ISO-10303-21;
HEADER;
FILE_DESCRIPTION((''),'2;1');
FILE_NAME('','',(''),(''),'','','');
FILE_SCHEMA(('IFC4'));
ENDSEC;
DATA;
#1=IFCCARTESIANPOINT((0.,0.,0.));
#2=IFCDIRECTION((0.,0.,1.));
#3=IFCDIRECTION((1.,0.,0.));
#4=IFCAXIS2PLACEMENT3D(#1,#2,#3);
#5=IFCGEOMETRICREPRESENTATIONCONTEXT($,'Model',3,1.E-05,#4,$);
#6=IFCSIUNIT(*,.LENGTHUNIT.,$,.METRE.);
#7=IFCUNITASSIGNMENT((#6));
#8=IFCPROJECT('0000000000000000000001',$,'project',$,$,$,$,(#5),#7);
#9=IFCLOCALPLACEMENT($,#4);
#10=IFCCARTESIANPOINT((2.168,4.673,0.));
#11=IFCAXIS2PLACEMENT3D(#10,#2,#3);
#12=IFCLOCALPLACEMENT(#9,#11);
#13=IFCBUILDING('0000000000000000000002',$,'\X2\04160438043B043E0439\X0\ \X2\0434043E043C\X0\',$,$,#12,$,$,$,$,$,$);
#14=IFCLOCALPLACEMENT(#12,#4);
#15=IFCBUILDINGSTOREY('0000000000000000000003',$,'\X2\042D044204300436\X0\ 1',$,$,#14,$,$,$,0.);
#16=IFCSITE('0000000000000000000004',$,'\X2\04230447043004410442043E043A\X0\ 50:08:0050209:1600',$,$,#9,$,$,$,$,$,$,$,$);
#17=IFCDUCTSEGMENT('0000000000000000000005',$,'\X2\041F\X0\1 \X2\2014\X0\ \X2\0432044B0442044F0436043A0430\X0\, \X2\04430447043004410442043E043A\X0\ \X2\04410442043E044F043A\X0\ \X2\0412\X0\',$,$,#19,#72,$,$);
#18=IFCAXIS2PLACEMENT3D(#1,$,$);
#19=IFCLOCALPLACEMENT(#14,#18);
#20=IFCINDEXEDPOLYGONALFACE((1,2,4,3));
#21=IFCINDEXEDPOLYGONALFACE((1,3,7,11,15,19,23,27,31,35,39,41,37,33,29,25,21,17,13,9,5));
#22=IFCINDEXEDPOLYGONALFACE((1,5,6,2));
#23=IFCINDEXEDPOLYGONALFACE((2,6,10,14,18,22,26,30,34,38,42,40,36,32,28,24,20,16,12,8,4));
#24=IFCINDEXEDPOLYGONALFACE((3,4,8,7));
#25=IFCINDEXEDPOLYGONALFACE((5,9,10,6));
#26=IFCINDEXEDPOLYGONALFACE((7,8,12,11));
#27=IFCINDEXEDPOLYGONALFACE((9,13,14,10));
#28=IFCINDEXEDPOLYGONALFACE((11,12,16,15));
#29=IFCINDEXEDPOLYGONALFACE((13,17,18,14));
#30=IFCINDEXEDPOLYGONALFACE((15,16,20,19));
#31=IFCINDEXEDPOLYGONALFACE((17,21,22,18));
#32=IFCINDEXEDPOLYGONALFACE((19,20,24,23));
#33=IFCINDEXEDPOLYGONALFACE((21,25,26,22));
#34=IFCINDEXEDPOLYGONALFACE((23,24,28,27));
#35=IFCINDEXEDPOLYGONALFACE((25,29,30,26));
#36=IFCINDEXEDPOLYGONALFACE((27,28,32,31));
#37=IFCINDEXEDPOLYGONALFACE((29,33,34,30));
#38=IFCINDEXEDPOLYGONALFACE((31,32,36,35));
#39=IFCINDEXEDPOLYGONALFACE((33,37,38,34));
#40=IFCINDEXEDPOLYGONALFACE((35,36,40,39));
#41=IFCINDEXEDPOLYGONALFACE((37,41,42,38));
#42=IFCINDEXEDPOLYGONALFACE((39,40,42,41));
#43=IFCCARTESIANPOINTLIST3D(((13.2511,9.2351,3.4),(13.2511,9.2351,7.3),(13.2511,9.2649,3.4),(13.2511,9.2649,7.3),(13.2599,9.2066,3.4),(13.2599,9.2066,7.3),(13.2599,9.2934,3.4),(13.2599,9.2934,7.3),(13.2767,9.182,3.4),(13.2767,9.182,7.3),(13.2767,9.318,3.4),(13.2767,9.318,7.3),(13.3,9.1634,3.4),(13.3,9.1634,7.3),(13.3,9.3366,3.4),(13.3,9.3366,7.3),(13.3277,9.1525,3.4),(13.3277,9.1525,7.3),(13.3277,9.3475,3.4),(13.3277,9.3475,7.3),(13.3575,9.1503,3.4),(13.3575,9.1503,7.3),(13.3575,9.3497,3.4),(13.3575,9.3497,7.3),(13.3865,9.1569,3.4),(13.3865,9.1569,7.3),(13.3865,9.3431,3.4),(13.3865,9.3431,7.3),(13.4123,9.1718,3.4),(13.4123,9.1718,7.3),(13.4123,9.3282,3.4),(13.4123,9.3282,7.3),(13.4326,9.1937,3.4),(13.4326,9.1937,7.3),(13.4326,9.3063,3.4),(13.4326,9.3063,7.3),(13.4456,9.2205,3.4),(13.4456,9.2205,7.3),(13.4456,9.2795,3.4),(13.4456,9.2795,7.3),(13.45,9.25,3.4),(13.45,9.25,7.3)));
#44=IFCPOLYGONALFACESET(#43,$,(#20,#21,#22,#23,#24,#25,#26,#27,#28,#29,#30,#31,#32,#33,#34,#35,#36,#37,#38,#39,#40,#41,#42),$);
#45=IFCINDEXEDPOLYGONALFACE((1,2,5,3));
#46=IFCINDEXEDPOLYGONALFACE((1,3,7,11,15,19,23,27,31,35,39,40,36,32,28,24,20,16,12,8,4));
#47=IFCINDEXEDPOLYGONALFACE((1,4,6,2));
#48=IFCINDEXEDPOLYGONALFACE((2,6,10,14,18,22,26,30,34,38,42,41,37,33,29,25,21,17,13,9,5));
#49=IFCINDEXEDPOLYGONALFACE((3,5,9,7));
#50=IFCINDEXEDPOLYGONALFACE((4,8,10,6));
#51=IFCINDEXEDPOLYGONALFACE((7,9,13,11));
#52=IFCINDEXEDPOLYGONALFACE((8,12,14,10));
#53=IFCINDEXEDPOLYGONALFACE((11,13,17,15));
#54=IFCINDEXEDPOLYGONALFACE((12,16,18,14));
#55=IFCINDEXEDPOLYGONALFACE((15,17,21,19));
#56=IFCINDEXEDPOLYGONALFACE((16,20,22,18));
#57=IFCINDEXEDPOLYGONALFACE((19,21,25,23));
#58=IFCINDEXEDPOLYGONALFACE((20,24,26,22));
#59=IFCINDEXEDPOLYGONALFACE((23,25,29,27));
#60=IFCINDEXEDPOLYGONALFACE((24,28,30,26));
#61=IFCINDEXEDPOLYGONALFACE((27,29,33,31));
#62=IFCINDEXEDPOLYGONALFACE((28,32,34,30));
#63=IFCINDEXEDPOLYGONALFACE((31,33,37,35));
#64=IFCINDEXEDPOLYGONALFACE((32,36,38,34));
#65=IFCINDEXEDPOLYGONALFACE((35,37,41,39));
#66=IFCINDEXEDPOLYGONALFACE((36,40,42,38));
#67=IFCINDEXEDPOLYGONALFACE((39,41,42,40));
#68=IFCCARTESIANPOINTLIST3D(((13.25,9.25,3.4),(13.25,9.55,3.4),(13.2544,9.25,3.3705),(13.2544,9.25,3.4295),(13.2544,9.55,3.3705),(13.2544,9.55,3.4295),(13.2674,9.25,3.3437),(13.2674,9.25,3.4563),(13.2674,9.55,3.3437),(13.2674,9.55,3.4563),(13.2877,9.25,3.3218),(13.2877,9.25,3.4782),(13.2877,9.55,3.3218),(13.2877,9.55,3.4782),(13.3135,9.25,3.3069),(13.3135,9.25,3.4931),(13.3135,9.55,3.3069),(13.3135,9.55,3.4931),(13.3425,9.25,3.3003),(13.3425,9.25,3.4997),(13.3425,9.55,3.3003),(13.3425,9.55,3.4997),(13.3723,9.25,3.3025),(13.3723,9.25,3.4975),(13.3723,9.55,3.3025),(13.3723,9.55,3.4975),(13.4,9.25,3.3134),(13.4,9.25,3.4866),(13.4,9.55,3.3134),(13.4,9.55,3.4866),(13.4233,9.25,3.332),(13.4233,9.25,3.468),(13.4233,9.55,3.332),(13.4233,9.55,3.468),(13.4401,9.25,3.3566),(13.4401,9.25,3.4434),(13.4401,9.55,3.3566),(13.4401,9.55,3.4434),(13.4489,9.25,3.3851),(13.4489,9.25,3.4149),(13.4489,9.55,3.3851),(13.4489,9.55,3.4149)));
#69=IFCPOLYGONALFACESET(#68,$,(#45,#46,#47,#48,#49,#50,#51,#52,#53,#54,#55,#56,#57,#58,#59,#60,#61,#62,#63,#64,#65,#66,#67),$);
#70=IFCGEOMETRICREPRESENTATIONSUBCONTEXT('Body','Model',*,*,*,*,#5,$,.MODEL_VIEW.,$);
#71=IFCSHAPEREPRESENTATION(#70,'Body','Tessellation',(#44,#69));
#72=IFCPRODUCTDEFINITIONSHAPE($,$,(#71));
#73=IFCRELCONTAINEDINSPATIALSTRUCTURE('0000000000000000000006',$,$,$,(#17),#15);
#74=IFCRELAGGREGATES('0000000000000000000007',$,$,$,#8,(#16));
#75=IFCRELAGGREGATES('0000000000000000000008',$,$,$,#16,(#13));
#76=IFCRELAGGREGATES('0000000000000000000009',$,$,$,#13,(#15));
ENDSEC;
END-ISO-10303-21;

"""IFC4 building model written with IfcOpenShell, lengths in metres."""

from ifc_helpers import new_model, si_unit, frame, origin_with_axes, origin_2d, place, context, subcontext, project, spatial, circle, extrude, element, save


model = new_model("IFC4")

# Units and contexts
model_context = context("Model", 3, precision=1e-05, world=origin_with_axes())
body_context = subcontext(model_context, "Body", "Model", "MODEL_VIEW")
ifc_project = project(units=[si_unit("LENGTHUNIT", "METRE")], contexts=[model_context])

# Site, building, storey
site_placement = place(None, origin_with_axes())
site = spatial("IfcSite", under=ifc_project, at=site_placement, Name="Участок 50:08:0050209:1600")
building_placement = place(site_placement, frame((2.168, 4.673, 0.0), z_axis=(0.0, 0.0, 1.0), x_axis=(1.0, 0.0, 0.0)))
building = spatial("IfcBuilding", under=site, at=building_placement, Name="Жилой дом")
storey_placement = place(building_placement, origin_with_axes())
storey = spatial("IfcBuildingStorey", under=building, at=storey_placement, Name="Этаж 1", Elevation=0.0)

# Duct segment
duct_segment_1_placement = place(storey_placement, origin_with_axes())
element("IfcDuctSegment", 1, at=duct_segment_1_placement, inside=storey, Name="П1 — вытяжка, участок стояк В", context=body_context, shape_type="SweptSolid", body=[
    extrude(circle(Radius=0.1, at=origin_2d()), frame((13.35, 9.25, 7.3), z_axis=(0.0, 0.0, -1.0), x_axis=(1.0, 0.0, 0.0)), (0.0, 0.0, 1.0), 3.9),
    extrude(circle(Radius=0.1, at=origin_2d()), frame((13.35, 9.25, 3.4), z_axis=(0.0, 1.0, 0.0), x_axis=(-1.0, 0.0, 0.0)), (0.0, 0.0, 1.0), 0.3),
])

save(model, "model.ifc")
